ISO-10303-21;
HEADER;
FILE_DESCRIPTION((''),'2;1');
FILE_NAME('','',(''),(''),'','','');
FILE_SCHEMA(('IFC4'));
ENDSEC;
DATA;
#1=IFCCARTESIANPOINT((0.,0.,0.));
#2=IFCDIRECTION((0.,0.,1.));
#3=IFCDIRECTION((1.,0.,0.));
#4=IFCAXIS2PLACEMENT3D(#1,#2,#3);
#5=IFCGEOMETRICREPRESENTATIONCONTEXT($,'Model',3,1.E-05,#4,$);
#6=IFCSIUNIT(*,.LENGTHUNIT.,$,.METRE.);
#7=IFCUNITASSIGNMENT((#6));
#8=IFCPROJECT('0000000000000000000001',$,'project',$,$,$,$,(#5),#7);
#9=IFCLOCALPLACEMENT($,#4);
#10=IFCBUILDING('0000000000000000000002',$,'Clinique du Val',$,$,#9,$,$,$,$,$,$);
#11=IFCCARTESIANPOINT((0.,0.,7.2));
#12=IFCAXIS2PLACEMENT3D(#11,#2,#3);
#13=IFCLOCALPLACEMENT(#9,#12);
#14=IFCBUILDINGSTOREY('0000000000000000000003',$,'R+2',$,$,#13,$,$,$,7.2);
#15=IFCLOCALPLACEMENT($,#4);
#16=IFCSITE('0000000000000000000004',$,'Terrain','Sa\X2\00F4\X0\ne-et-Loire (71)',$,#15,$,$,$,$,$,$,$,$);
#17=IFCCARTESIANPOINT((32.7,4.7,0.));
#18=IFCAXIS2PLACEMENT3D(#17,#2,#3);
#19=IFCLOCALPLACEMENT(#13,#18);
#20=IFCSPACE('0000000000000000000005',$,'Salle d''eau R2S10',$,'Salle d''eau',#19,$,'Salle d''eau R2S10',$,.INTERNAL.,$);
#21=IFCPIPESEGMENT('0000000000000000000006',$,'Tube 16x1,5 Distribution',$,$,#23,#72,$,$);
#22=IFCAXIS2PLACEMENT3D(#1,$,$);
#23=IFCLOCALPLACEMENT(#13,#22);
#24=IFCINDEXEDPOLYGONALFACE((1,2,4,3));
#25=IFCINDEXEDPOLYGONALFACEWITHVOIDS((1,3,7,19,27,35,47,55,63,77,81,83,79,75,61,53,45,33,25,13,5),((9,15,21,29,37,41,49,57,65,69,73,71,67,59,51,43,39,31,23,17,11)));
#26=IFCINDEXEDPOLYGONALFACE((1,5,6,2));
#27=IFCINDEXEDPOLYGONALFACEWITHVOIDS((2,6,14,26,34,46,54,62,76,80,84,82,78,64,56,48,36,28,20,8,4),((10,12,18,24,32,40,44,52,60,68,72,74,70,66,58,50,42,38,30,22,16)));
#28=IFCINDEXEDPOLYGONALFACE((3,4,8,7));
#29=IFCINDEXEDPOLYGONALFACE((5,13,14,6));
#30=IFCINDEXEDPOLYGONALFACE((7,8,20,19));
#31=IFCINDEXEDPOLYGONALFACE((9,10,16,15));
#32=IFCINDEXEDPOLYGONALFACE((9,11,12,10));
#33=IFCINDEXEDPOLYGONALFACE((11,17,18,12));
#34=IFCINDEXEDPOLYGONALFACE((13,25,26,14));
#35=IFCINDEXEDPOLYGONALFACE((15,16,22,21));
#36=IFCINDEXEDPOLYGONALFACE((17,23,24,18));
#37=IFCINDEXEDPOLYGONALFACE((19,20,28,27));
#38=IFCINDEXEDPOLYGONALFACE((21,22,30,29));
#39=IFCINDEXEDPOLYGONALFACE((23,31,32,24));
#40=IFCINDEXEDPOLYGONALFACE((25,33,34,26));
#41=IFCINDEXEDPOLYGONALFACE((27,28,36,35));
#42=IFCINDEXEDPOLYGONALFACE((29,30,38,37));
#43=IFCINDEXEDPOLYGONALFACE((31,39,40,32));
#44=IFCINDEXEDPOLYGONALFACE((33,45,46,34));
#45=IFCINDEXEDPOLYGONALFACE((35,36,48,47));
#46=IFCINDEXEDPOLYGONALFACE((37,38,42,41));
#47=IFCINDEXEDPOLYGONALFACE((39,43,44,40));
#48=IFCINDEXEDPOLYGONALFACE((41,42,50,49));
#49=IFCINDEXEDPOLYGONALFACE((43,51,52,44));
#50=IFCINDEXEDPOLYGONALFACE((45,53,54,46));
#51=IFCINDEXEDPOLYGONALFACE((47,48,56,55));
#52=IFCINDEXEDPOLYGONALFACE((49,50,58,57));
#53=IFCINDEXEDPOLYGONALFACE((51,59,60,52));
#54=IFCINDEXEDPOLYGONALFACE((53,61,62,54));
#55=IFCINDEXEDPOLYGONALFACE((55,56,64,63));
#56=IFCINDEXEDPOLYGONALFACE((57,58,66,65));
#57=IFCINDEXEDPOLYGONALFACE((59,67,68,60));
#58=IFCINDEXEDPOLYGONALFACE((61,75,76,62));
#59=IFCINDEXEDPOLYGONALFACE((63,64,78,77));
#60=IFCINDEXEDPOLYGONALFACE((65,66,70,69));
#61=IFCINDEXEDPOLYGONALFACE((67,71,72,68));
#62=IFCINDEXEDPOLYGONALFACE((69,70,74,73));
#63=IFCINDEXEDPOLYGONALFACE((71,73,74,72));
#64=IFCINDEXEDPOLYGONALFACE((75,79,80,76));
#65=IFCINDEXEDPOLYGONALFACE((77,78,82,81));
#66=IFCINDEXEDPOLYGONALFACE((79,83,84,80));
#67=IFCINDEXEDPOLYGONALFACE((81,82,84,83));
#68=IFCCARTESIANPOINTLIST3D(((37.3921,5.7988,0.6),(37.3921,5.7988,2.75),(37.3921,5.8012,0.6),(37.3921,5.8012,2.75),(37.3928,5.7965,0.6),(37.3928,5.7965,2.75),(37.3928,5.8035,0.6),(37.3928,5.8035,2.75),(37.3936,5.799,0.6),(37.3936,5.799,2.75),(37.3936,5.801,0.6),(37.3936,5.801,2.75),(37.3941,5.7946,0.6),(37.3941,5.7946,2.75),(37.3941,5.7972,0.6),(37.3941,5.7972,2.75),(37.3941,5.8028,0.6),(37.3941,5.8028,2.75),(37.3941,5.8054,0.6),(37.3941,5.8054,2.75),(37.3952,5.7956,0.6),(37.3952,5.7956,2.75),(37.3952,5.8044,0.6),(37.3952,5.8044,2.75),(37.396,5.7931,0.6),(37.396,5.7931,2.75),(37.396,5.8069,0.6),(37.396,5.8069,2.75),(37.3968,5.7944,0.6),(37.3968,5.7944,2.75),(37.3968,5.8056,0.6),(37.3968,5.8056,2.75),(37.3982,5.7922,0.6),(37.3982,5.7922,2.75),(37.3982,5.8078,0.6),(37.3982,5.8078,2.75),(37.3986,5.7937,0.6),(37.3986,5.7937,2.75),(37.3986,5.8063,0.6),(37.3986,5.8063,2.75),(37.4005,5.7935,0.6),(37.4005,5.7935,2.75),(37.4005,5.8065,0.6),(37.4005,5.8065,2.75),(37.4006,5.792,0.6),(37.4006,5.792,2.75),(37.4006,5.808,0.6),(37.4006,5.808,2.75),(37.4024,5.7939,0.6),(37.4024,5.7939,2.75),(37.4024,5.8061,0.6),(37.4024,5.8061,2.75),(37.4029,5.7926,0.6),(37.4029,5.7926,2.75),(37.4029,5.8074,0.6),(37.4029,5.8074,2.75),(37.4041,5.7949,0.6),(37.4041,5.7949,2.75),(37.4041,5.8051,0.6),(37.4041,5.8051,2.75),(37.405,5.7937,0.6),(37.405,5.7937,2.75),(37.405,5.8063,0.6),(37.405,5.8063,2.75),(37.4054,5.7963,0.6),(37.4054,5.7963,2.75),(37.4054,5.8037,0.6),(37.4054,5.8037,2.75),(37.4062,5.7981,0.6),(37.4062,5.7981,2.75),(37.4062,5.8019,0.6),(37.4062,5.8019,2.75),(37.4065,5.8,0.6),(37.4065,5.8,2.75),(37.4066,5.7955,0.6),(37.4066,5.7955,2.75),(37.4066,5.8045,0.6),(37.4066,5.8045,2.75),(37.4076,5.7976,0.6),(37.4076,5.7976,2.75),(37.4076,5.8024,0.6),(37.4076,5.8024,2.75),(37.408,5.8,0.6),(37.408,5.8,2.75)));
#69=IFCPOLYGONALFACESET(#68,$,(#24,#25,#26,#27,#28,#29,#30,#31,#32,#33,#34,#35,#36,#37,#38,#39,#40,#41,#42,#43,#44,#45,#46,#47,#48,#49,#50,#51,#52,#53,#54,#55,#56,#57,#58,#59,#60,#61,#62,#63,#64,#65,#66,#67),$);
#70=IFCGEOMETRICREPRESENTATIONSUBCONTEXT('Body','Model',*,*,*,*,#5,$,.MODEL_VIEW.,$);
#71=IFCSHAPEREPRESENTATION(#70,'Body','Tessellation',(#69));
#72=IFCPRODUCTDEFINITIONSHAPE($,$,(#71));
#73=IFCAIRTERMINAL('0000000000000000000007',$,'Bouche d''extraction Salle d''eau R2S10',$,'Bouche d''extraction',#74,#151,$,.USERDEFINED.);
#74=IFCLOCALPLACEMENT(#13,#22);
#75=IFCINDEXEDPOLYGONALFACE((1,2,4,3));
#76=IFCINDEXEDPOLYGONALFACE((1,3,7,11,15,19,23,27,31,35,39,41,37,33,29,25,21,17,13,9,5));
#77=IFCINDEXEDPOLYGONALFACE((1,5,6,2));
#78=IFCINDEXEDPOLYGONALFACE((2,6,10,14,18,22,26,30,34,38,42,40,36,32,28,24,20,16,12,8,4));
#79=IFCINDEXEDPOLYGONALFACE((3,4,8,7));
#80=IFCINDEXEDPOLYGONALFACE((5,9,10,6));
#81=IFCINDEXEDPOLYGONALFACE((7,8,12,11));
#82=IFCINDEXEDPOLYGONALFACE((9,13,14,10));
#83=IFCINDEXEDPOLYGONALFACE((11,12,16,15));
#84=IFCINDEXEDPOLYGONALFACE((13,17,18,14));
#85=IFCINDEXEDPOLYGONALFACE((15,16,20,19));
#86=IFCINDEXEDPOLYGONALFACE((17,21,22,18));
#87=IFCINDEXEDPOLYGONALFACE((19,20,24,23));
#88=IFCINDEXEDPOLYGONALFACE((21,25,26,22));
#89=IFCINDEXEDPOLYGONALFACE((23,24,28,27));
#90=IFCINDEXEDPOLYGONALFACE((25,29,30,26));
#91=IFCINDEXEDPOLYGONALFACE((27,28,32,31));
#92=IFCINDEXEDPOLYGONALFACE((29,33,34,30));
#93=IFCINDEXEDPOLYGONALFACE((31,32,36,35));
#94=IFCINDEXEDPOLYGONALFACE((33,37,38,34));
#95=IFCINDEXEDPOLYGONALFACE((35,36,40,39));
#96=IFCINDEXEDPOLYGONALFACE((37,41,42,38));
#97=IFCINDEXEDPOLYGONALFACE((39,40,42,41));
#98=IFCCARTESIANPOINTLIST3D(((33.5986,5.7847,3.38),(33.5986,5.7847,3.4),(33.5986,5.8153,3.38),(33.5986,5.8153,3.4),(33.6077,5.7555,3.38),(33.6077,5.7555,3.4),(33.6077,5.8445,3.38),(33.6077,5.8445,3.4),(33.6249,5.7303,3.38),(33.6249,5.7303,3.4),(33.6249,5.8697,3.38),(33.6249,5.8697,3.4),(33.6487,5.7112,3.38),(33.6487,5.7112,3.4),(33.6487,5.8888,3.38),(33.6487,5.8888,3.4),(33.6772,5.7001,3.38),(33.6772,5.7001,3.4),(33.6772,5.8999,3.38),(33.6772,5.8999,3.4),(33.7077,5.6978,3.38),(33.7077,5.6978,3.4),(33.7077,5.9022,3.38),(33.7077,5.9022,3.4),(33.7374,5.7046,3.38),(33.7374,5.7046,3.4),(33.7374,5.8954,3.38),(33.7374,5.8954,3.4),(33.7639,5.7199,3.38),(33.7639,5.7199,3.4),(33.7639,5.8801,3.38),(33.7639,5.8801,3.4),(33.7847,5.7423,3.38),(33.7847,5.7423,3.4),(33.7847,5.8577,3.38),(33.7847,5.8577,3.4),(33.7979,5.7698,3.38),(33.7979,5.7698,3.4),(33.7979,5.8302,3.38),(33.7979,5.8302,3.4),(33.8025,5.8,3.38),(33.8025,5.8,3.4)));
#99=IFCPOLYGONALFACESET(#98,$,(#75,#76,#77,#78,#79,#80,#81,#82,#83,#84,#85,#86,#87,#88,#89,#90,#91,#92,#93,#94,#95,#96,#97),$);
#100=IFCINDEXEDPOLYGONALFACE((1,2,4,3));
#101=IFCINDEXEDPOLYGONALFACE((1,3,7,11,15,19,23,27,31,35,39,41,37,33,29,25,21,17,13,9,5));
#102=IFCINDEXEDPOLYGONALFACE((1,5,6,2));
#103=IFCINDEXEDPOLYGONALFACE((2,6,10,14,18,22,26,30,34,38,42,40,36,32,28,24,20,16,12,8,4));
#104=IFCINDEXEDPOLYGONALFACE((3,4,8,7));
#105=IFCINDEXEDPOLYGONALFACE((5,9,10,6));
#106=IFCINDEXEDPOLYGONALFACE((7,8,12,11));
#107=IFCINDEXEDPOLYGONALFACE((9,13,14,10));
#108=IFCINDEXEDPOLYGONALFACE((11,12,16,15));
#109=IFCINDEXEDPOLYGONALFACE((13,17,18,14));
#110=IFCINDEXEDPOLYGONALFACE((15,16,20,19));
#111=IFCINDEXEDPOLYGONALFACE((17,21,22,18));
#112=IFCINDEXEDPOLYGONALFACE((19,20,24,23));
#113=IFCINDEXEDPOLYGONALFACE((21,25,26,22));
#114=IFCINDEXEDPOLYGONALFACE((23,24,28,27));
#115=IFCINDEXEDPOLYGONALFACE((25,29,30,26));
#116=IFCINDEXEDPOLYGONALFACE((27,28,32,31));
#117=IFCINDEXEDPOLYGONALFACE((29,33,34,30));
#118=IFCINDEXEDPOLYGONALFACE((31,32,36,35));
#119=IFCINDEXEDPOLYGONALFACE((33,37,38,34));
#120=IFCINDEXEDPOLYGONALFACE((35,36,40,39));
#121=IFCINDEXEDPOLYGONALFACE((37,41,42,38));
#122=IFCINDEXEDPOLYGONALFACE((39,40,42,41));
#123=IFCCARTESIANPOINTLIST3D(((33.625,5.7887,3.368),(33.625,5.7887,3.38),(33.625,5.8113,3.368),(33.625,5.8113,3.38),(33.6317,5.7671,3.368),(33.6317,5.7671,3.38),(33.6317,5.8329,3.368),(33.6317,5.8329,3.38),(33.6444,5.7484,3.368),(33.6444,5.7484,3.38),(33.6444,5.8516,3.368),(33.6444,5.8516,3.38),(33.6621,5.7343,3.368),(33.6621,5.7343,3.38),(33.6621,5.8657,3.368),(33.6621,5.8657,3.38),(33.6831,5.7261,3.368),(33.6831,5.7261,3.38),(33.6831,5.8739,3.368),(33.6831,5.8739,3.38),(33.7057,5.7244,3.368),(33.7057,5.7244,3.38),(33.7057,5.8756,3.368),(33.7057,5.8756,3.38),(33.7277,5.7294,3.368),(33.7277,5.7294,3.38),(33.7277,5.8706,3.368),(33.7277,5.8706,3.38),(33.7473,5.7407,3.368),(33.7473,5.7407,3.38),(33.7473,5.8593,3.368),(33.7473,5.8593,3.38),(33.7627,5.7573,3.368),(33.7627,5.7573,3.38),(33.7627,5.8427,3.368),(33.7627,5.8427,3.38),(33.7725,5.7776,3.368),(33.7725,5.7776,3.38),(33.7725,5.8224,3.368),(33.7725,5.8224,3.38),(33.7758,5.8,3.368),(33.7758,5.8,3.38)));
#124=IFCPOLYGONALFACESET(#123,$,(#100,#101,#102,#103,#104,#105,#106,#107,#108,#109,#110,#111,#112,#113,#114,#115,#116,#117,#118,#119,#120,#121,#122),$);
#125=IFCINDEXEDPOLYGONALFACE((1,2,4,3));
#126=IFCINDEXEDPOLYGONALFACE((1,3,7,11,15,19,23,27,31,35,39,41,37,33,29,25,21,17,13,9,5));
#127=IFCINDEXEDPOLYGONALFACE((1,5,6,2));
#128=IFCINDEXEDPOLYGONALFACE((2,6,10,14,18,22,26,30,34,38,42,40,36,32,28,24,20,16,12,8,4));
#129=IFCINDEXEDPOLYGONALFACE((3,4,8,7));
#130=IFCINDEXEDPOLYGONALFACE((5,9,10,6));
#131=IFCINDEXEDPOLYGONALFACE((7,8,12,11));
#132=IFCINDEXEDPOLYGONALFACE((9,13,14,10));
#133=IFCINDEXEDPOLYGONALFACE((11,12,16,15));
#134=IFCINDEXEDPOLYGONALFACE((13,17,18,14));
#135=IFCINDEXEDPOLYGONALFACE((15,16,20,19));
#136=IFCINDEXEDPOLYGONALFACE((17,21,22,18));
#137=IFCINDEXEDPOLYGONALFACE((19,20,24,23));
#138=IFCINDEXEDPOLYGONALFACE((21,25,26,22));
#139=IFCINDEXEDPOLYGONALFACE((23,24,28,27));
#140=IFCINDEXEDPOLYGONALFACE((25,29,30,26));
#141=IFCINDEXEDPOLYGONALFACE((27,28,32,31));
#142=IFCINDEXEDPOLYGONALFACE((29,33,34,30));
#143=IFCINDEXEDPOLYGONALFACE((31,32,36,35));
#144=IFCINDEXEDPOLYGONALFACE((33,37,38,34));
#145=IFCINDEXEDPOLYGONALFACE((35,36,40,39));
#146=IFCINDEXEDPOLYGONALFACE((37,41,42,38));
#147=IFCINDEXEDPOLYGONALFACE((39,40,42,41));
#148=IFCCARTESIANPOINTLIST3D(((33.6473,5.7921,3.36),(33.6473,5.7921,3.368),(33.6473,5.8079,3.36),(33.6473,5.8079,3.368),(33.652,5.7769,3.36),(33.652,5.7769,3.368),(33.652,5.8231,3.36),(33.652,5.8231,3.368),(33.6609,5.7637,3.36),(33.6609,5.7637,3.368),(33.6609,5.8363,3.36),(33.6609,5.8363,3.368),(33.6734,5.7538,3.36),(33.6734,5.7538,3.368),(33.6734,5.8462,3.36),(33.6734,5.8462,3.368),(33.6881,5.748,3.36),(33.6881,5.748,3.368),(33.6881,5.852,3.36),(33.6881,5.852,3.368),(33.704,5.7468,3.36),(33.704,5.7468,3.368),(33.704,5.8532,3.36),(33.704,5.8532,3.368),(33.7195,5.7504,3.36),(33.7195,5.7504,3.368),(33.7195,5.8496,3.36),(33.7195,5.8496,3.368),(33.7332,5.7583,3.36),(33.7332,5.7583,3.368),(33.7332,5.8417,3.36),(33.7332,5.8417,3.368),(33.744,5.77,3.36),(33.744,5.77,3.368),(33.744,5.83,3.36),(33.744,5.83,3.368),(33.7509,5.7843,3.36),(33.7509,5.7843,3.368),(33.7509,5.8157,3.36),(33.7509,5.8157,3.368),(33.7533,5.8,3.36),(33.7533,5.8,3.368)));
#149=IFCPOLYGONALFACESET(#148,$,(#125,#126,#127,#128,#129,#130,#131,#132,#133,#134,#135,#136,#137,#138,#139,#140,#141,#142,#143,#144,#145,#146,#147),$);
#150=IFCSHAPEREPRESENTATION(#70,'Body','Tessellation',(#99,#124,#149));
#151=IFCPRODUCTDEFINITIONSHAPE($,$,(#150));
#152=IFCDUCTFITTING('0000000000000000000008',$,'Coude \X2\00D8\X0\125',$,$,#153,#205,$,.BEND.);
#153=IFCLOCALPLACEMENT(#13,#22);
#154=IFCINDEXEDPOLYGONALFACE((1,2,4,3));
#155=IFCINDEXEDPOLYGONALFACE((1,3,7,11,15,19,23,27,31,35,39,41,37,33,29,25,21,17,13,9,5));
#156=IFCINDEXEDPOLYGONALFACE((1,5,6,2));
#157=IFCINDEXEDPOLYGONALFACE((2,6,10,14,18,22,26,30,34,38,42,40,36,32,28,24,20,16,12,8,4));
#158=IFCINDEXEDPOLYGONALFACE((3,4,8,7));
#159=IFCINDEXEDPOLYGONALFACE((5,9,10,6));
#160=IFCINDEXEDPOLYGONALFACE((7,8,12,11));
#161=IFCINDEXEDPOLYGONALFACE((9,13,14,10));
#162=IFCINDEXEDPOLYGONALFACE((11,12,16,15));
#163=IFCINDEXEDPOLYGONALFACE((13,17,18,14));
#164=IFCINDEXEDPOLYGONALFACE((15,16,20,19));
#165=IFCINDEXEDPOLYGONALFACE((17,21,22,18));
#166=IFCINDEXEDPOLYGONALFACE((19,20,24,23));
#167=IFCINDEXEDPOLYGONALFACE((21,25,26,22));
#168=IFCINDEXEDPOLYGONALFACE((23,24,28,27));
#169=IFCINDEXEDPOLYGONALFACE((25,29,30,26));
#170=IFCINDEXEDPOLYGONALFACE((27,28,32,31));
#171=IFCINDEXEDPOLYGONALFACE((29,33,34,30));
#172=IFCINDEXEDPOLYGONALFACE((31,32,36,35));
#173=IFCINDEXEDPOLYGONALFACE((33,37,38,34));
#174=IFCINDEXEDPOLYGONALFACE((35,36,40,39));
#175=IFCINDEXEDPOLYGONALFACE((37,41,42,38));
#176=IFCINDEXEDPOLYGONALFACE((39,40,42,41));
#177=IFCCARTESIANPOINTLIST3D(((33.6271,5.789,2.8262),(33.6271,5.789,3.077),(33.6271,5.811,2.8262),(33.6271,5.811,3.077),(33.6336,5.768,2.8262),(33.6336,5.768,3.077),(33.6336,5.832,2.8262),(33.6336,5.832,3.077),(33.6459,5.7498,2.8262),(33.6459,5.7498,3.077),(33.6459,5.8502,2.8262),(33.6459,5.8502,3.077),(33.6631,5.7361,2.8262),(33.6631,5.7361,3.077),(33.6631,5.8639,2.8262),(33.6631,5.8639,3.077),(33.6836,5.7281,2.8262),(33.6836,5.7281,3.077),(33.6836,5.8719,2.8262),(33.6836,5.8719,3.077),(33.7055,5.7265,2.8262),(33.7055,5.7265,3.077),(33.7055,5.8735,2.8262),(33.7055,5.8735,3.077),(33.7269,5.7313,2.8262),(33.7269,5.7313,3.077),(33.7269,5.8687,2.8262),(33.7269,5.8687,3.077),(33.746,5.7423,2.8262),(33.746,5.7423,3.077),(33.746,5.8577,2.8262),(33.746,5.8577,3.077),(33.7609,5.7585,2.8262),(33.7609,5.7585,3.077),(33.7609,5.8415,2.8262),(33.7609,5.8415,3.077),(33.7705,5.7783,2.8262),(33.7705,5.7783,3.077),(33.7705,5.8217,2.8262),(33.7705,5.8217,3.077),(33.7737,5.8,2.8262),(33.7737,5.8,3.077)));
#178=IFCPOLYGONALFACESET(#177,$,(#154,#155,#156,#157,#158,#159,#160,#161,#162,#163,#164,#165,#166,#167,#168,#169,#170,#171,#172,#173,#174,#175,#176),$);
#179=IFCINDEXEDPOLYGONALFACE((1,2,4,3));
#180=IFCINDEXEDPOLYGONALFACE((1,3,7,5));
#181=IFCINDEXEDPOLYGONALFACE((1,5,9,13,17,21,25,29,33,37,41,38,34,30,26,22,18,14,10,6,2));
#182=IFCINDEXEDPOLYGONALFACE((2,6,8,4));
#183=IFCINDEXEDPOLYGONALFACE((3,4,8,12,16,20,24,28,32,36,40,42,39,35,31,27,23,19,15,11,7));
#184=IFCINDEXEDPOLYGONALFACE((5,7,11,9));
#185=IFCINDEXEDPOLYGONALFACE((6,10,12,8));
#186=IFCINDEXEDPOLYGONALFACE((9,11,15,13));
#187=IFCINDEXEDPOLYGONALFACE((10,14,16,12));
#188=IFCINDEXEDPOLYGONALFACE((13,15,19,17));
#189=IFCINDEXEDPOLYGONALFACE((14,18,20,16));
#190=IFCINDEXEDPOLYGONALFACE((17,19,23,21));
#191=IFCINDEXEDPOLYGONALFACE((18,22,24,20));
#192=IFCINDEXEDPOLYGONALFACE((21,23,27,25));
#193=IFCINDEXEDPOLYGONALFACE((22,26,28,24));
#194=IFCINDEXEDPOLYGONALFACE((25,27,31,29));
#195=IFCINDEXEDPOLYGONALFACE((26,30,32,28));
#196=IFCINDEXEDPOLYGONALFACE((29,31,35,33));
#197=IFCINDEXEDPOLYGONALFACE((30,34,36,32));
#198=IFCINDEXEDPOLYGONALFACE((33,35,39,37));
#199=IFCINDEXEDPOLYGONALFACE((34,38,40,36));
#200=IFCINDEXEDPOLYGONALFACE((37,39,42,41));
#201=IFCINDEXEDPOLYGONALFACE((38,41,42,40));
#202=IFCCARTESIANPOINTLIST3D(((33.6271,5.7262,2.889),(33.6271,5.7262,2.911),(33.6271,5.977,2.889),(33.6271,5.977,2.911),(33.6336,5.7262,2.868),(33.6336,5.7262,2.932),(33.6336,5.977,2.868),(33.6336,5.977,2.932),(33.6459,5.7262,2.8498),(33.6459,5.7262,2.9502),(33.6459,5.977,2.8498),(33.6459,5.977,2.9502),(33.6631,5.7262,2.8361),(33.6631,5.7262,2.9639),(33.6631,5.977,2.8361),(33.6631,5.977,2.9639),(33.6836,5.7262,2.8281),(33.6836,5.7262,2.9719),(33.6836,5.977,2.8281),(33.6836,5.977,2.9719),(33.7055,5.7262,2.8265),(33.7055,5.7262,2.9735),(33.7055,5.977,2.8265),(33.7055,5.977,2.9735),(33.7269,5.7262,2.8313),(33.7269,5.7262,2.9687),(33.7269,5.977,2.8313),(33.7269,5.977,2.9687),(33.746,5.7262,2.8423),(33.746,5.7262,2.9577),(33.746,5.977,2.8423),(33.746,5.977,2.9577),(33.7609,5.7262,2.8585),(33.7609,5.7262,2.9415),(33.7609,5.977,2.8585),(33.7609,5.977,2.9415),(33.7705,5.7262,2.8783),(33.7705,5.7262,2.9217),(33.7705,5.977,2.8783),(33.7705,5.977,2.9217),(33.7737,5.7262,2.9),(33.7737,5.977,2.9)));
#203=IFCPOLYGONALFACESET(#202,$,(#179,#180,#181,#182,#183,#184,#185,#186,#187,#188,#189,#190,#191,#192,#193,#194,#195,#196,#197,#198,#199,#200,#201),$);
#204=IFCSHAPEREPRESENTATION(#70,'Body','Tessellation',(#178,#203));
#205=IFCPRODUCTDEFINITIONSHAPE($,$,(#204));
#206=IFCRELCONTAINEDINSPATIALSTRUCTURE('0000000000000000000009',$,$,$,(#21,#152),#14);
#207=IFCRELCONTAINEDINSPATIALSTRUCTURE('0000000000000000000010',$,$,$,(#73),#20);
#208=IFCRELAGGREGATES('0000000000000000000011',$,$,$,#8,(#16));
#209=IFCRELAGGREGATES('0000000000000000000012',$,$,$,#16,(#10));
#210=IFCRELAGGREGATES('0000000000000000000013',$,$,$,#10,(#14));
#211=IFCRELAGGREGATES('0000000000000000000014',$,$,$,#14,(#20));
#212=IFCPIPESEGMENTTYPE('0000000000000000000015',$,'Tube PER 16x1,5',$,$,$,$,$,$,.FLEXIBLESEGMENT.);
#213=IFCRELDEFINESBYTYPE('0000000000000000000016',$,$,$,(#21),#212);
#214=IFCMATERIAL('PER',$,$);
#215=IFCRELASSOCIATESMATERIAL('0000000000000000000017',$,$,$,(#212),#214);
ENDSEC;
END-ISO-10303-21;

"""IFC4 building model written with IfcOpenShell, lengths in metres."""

from ifc_helpers import new_model, si_unit, frame, origin_with_axes, place, context, subcontext, project, spatial, circle, hollow_circle, extrude, material, type_object, element, save


model = new_model("IFC4")

# Units and contexts
model_context = context("Model", 3, precision=1e-05, world=origin_with_axes())
body_context = subcontext(model_context, "Body", "Model", "MODEL_VIEW")
ifc_project = project(units=[si_unit("LENGTHUNIT", "METRE")], contexts=[model_context])

# Site, building, storey
site_placement = place(None, origin_with_axes())
site = spatial("IfcSite", under=ifc_project, at=site_placement, Name="Terrain", Description="Saône-et-Loire (71)")
building_placement = place(None, origin_with_axes())
building = spatial("IfcBuilding", under=site, at=building_placement, Name="Clinique du Val")
storey_placement = place(building_placement, frame((0.0, 0.0, 7.2), z_axis=(0.0, 0.0, 1.0), x_axis=(1.0, 0.0, 0.0)))
storey = spatial("IfcBuildingStorey", under=building, at=storey_placement, Name="R+2", Elevation=7.2)

# Pipe segment
ifc_material_1 = material(Name="PER")
pipe_segment_type_1 = type_object("IfcPipeSegmentType", Name="Tube PER 16x1,5", PredefinedType="FLEXIBLESEGMENT", material=ifc_material_1)
pipe_segment_1_placement = place(storey_placement, frame((37.4, 5.8, 2.75), z_axis=(0.0, 0.0, -1.0), x_axis=(1.0, 0.0, 0.0)))
element("IfcPipeSegment", 1, at=pipe_segment_1_placement, inside=storey, type_object=pipe_segment_type_1, Name="Tube 16x1,5 Distribution", context=body_context, shape_type="SweptSolid", body=[
    extrude(hollow_circle(Radius=0.008, WallThickness=0.0015), origin_with_axes(), (0.0, 0.0, 1.0), 2.15),
])

# Shared definitions
space_1_placement = place(storey_placement, frame((32.7, 4.7, 0.0), z_axis=(0.0, 0.0, 1.0), x_axis=(1.0, 0.0, 0.0)))
space_1 = spatial("IfcSpace", under=storey, at=space_1_placement, Name="Salle d'eau R2S10", ObjectType="Salle d'eau", LongName="Salle d'eau R2S10", PredefinedType="INTERNAL")

# Air terminal
air_terminal_1_placement = place(space_1_placement, frame((1.0, 1.1, 3.36), z_axis=(0.0, 0.0, 1.0), x_axis=(1.0, 0.0, 0.0)))
element("IfcAirTerminal", 2, at=air_terminal_1_placement, inside=space_1, Name="Bouche d'extraction Salle d'eau R2S10", ObjectType="Bouche d'extraction", PredefinedType="USERDEFINED", context=body_context, shape_type="SweptSolid", body=[
    extrude(circle(Radius=0.1025), frame((0.0, 0.0, 0.02), z_axis=(0.0, 0.0, 1.0), x_axis=(1.0, 0.0, 0.0)), (0.0, 0.0, 1.0), 0.02),
    extrude(circle(Radius=0.0759), frame((0.0, 0.0, 0.008), z_axis=(0.0, 0.0, 1.0), x_axis=(1.0, 0.0, 0.0)), (0.0, 0.0, 1.0), 0.012),
    extrude(circle(Radius=0.0533), origin_with_axes(), (0.0, 0.0, 1.0), 0.008),
])

# Duct fitting
duct_fitting_1_placement = place(storey_placement, frame((33.7, 5.8, 2.9), z_axis=(0.0, 0.0, 1.0), x_axis=(1.0, 0.0, 0.0)))
element("IfcDuctFitting", 3, at=duct_fitting_1_placement, inside=storey, Name="Coude Ø125", PredefinedType="BEND", context=body_context, shape_type="SweptSolid", body=[
    extrude(circle(Radius=0.0737), frame((0.0, 0.0, -0.0737), z_axis=(0.0, 0.0, 1.0), x_axis=(1.0, 0.0, 0.0)), (0.0, 0.0, 1.0), 0.2507),
    extrude(circle(Radius=0.0737), frame((0.0, -0.0737, 0.0), z_axis=(0.0, 1.0, 0.0), x_axis=(1.0, 0.0, 0.0)), (0.0, 0.0, 1.0), 0.2507),
])

save(model, "model.ifc")
